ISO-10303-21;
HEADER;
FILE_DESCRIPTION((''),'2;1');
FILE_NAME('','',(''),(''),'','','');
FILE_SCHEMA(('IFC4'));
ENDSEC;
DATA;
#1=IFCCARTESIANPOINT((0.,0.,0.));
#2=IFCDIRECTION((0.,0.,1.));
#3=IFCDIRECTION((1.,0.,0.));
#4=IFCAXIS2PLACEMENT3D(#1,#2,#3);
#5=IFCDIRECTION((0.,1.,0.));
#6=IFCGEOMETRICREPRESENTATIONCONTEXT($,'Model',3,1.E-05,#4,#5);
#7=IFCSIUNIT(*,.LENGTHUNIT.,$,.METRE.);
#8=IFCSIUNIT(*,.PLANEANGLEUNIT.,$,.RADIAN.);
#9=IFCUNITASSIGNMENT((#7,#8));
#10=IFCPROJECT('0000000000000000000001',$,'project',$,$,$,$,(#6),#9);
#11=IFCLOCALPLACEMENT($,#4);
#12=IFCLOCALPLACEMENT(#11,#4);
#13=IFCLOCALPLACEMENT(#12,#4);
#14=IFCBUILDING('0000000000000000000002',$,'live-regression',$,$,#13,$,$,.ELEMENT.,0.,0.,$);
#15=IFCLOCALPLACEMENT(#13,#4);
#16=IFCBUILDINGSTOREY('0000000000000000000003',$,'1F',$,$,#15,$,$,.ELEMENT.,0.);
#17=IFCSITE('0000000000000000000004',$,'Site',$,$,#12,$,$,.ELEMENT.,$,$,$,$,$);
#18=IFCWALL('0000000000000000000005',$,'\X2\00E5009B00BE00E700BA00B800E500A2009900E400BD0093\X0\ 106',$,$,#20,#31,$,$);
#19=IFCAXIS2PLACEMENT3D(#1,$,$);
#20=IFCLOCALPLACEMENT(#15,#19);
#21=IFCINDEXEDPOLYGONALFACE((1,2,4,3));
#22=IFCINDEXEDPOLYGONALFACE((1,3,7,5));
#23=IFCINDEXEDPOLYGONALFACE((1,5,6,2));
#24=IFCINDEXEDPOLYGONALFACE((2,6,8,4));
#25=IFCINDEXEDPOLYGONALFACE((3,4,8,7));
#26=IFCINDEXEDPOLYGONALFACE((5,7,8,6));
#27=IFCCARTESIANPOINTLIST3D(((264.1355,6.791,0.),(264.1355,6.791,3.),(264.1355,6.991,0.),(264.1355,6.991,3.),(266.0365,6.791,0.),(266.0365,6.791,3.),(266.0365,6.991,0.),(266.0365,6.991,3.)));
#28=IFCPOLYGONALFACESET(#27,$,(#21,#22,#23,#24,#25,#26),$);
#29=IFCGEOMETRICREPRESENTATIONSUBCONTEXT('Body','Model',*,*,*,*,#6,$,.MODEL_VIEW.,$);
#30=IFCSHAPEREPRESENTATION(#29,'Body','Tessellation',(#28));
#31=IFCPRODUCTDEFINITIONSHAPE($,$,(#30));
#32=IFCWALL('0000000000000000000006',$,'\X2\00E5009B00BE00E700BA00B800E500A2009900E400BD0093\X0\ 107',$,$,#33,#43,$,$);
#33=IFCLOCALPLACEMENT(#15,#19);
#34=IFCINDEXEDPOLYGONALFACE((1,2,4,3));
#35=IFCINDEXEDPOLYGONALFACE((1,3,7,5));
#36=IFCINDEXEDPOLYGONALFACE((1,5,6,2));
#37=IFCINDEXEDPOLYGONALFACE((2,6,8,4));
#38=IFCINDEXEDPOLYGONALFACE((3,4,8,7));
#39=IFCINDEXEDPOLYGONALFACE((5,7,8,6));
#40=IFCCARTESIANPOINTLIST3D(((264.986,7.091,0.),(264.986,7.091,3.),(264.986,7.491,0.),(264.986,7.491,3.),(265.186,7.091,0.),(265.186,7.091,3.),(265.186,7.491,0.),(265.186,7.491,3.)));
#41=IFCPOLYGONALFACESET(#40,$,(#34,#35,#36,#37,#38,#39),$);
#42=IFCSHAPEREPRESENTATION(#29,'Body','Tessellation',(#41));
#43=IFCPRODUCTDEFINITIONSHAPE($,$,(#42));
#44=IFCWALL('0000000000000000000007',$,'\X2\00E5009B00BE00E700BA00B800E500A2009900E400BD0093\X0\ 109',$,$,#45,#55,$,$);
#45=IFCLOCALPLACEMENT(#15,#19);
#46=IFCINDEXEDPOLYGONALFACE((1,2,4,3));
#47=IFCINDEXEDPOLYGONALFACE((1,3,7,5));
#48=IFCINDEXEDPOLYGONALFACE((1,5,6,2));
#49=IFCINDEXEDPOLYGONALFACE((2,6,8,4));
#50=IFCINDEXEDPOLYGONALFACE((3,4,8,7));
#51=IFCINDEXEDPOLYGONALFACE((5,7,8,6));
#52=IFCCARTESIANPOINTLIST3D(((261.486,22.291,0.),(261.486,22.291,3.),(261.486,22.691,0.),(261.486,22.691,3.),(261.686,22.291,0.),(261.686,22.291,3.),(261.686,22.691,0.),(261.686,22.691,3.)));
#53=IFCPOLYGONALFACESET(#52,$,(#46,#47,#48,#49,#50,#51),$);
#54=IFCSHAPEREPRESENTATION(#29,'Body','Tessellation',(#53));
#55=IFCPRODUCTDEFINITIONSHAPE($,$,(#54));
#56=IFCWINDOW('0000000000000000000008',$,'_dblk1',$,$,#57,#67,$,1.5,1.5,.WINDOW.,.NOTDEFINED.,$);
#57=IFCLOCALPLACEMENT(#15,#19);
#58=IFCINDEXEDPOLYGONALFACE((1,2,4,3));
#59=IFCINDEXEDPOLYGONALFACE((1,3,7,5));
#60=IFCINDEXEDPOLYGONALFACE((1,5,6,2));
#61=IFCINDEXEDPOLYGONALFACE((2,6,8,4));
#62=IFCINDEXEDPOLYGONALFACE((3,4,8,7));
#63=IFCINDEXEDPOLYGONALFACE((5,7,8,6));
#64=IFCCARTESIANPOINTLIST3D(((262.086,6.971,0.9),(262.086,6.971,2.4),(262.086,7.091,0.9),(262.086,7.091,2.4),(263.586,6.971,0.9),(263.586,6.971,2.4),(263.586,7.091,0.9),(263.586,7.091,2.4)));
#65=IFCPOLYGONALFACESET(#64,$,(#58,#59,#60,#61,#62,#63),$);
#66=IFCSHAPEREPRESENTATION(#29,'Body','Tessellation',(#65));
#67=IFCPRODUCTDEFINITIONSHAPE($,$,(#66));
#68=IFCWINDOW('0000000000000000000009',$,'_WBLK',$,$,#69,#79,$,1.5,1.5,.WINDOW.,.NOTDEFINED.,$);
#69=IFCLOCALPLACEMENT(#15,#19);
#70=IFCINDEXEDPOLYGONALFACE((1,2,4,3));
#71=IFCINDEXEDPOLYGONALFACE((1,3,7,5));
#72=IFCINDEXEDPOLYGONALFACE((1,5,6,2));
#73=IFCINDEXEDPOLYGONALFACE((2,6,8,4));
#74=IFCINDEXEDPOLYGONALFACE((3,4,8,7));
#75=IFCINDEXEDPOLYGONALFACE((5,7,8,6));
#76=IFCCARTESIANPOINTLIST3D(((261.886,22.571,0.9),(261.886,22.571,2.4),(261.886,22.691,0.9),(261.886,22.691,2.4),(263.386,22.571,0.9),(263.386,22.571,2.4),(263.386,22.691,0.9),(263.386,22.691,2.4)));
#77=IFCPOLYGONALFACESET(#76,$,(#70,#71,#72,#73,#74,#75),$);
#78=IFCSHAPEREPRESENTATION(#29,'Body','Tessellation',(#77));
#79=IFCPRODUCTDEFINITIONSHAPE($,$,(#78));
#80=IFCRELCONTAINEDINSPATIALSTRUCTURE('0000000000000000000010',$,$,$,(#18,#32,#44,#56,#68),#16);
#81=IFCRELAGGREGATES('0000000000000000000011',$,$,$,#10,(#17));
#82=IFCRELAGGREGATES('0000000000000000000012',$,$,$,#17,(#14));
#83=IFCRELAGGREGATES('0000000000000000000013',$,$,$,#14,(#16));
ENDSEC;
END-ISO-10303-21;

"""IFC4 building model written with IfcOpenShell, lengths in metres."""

from ifc_helpers import new_model, si_unit, direction, frame, frame_2d, origin_with_axes, place, context, subcontext, project, spatial, rectangle, extrude, element, save


model = new_model("IFC4")

# Units and contexts
model_context = context("Model", 3, precision=1e-05, world=origin_with_axes(), true_north=direction((0.0, 1.0, 0.0)))
body_context = subcontext(model_context, "Body", "Model", "MODEL_VIEW")
ifc_project = project(units=[si_unit("LENGTHUNIT", "METRE"), si_unit("PLANEANGLEUNIT", "RADIAN")], contexts=[model_context])

# Site, building, storey
placement = place(None, origin_with_axes())
site_placement = place(placement, origin_with_axes())
site = spatial("IfcSite", under=ifc_project, at=site_placement, Name="Site", CompositionType="ELEMENT")
building_placement = place(site_placement, origin_with_axes())
building = spatial("IfcBuilding", under=site, at=building_placement, Name="live-regression", CompositionType="ELEMENT", ElevationOfRefHeight=0.0, ElevationOfTerrain=0.0)
storey_placement = place(building_placement, origin_with_axes())
storey = spatial("IfcBuildingStorey", under=building, at=storey_placement, Name="1F", CompositionType="ELEMENT", Elevation=0.0)

# Walls
wall_1_placement = place(storey_placement, frame((265.086, 6.891, 0.0), z_axis=(0.0, 0.0, 1.0), x_axis=(1.0, 0.0, 0.0)))
element("IfcWall", 1, at=wall_1_placement, inside=storey, Name="å\u009b¾çº¸å¢\u0099ä½\u0093 106", context=body_context, shape_type="SweptSolid", body=[
    extrude(rectangle(XDim=1.901, YDim=0.2, at=frame_2d((0.0, 0.0), x_axis=(1.0, 0.0, 0.0))), frame((0.0, 0.0, 0.0), z_axis=(0.0, 0.0, 1.0)), (0.0, 0.0, 1.0), 3.0),
])
for number, where, z_axis, x_axis, name in (
    (2, (265.086, 7.291, 0.0), (0.0, 0.0, 1.0), (0.0, -1.0, 0.0), "å\u009b¾çº¸å¢\u0099ä½\u0093 107"),
    (3, (261.586, 22.491, 0.0), (0.0, 0.0, 1.0), (0.0, 1.0, 0.0), "å\u009b¾çº¸å¢\u0099ä½\u0093 109"),
):
    element("IfcWall", number, at=place(storey_placement, frame(where, z_axis=z_axis, x_axis=x_axis)), inside=storey, Name=name, context=body_context, shape_type="SweptSolid", body=[
        extrude(rectangle(XDim=0.4, YDim=0.2, at=frame_2d((0.0, 0.0), x_axis=(1.0, 0.0, 0.0))), frame((0.0, 0.0, 0.0), z_axis=(0.0, 0.0, 1.0)), (0.0, 0.0, 1.0), 3.0),
    ])

# Windows
for number, where, z_axis, x_axis, name in (
    (4, (262.836, 7.031, 0.9), (0.0, 0.0, 1.0), (1.0, 0.0, 0.0), "_dblk1"),
    (5, (262.636, 22.631, 0.9), (0.0, 0.0, 1.0), (1.0, 0.0, 0.0), "_WBLK"),
):
    element("IfcWindow", number, at=place(storey_placement, frame(where, z_axis=z_axis, x_axis=x_axis)), inside=storey, Name=name, OverallHeight=1.5, OverallWidth=1.5, PartitioningType="NOTDEFINED", PredefinedType="WINDOW", context=body_context, shape_type="SweptSolid", body=[
        extrude(rectangle(XDim=1.5, YDim=0.12, at=frame_2d((0.0, 0.0), x_axis=(1.0, 0.0, 0.0))), frame((0.0, 0.0, 0.0), z_axis=(0.0, 0.0, 1.0)), (0.0, 0.0, 1.0), 1.5),
    ])

save(model, "model.ifc")
